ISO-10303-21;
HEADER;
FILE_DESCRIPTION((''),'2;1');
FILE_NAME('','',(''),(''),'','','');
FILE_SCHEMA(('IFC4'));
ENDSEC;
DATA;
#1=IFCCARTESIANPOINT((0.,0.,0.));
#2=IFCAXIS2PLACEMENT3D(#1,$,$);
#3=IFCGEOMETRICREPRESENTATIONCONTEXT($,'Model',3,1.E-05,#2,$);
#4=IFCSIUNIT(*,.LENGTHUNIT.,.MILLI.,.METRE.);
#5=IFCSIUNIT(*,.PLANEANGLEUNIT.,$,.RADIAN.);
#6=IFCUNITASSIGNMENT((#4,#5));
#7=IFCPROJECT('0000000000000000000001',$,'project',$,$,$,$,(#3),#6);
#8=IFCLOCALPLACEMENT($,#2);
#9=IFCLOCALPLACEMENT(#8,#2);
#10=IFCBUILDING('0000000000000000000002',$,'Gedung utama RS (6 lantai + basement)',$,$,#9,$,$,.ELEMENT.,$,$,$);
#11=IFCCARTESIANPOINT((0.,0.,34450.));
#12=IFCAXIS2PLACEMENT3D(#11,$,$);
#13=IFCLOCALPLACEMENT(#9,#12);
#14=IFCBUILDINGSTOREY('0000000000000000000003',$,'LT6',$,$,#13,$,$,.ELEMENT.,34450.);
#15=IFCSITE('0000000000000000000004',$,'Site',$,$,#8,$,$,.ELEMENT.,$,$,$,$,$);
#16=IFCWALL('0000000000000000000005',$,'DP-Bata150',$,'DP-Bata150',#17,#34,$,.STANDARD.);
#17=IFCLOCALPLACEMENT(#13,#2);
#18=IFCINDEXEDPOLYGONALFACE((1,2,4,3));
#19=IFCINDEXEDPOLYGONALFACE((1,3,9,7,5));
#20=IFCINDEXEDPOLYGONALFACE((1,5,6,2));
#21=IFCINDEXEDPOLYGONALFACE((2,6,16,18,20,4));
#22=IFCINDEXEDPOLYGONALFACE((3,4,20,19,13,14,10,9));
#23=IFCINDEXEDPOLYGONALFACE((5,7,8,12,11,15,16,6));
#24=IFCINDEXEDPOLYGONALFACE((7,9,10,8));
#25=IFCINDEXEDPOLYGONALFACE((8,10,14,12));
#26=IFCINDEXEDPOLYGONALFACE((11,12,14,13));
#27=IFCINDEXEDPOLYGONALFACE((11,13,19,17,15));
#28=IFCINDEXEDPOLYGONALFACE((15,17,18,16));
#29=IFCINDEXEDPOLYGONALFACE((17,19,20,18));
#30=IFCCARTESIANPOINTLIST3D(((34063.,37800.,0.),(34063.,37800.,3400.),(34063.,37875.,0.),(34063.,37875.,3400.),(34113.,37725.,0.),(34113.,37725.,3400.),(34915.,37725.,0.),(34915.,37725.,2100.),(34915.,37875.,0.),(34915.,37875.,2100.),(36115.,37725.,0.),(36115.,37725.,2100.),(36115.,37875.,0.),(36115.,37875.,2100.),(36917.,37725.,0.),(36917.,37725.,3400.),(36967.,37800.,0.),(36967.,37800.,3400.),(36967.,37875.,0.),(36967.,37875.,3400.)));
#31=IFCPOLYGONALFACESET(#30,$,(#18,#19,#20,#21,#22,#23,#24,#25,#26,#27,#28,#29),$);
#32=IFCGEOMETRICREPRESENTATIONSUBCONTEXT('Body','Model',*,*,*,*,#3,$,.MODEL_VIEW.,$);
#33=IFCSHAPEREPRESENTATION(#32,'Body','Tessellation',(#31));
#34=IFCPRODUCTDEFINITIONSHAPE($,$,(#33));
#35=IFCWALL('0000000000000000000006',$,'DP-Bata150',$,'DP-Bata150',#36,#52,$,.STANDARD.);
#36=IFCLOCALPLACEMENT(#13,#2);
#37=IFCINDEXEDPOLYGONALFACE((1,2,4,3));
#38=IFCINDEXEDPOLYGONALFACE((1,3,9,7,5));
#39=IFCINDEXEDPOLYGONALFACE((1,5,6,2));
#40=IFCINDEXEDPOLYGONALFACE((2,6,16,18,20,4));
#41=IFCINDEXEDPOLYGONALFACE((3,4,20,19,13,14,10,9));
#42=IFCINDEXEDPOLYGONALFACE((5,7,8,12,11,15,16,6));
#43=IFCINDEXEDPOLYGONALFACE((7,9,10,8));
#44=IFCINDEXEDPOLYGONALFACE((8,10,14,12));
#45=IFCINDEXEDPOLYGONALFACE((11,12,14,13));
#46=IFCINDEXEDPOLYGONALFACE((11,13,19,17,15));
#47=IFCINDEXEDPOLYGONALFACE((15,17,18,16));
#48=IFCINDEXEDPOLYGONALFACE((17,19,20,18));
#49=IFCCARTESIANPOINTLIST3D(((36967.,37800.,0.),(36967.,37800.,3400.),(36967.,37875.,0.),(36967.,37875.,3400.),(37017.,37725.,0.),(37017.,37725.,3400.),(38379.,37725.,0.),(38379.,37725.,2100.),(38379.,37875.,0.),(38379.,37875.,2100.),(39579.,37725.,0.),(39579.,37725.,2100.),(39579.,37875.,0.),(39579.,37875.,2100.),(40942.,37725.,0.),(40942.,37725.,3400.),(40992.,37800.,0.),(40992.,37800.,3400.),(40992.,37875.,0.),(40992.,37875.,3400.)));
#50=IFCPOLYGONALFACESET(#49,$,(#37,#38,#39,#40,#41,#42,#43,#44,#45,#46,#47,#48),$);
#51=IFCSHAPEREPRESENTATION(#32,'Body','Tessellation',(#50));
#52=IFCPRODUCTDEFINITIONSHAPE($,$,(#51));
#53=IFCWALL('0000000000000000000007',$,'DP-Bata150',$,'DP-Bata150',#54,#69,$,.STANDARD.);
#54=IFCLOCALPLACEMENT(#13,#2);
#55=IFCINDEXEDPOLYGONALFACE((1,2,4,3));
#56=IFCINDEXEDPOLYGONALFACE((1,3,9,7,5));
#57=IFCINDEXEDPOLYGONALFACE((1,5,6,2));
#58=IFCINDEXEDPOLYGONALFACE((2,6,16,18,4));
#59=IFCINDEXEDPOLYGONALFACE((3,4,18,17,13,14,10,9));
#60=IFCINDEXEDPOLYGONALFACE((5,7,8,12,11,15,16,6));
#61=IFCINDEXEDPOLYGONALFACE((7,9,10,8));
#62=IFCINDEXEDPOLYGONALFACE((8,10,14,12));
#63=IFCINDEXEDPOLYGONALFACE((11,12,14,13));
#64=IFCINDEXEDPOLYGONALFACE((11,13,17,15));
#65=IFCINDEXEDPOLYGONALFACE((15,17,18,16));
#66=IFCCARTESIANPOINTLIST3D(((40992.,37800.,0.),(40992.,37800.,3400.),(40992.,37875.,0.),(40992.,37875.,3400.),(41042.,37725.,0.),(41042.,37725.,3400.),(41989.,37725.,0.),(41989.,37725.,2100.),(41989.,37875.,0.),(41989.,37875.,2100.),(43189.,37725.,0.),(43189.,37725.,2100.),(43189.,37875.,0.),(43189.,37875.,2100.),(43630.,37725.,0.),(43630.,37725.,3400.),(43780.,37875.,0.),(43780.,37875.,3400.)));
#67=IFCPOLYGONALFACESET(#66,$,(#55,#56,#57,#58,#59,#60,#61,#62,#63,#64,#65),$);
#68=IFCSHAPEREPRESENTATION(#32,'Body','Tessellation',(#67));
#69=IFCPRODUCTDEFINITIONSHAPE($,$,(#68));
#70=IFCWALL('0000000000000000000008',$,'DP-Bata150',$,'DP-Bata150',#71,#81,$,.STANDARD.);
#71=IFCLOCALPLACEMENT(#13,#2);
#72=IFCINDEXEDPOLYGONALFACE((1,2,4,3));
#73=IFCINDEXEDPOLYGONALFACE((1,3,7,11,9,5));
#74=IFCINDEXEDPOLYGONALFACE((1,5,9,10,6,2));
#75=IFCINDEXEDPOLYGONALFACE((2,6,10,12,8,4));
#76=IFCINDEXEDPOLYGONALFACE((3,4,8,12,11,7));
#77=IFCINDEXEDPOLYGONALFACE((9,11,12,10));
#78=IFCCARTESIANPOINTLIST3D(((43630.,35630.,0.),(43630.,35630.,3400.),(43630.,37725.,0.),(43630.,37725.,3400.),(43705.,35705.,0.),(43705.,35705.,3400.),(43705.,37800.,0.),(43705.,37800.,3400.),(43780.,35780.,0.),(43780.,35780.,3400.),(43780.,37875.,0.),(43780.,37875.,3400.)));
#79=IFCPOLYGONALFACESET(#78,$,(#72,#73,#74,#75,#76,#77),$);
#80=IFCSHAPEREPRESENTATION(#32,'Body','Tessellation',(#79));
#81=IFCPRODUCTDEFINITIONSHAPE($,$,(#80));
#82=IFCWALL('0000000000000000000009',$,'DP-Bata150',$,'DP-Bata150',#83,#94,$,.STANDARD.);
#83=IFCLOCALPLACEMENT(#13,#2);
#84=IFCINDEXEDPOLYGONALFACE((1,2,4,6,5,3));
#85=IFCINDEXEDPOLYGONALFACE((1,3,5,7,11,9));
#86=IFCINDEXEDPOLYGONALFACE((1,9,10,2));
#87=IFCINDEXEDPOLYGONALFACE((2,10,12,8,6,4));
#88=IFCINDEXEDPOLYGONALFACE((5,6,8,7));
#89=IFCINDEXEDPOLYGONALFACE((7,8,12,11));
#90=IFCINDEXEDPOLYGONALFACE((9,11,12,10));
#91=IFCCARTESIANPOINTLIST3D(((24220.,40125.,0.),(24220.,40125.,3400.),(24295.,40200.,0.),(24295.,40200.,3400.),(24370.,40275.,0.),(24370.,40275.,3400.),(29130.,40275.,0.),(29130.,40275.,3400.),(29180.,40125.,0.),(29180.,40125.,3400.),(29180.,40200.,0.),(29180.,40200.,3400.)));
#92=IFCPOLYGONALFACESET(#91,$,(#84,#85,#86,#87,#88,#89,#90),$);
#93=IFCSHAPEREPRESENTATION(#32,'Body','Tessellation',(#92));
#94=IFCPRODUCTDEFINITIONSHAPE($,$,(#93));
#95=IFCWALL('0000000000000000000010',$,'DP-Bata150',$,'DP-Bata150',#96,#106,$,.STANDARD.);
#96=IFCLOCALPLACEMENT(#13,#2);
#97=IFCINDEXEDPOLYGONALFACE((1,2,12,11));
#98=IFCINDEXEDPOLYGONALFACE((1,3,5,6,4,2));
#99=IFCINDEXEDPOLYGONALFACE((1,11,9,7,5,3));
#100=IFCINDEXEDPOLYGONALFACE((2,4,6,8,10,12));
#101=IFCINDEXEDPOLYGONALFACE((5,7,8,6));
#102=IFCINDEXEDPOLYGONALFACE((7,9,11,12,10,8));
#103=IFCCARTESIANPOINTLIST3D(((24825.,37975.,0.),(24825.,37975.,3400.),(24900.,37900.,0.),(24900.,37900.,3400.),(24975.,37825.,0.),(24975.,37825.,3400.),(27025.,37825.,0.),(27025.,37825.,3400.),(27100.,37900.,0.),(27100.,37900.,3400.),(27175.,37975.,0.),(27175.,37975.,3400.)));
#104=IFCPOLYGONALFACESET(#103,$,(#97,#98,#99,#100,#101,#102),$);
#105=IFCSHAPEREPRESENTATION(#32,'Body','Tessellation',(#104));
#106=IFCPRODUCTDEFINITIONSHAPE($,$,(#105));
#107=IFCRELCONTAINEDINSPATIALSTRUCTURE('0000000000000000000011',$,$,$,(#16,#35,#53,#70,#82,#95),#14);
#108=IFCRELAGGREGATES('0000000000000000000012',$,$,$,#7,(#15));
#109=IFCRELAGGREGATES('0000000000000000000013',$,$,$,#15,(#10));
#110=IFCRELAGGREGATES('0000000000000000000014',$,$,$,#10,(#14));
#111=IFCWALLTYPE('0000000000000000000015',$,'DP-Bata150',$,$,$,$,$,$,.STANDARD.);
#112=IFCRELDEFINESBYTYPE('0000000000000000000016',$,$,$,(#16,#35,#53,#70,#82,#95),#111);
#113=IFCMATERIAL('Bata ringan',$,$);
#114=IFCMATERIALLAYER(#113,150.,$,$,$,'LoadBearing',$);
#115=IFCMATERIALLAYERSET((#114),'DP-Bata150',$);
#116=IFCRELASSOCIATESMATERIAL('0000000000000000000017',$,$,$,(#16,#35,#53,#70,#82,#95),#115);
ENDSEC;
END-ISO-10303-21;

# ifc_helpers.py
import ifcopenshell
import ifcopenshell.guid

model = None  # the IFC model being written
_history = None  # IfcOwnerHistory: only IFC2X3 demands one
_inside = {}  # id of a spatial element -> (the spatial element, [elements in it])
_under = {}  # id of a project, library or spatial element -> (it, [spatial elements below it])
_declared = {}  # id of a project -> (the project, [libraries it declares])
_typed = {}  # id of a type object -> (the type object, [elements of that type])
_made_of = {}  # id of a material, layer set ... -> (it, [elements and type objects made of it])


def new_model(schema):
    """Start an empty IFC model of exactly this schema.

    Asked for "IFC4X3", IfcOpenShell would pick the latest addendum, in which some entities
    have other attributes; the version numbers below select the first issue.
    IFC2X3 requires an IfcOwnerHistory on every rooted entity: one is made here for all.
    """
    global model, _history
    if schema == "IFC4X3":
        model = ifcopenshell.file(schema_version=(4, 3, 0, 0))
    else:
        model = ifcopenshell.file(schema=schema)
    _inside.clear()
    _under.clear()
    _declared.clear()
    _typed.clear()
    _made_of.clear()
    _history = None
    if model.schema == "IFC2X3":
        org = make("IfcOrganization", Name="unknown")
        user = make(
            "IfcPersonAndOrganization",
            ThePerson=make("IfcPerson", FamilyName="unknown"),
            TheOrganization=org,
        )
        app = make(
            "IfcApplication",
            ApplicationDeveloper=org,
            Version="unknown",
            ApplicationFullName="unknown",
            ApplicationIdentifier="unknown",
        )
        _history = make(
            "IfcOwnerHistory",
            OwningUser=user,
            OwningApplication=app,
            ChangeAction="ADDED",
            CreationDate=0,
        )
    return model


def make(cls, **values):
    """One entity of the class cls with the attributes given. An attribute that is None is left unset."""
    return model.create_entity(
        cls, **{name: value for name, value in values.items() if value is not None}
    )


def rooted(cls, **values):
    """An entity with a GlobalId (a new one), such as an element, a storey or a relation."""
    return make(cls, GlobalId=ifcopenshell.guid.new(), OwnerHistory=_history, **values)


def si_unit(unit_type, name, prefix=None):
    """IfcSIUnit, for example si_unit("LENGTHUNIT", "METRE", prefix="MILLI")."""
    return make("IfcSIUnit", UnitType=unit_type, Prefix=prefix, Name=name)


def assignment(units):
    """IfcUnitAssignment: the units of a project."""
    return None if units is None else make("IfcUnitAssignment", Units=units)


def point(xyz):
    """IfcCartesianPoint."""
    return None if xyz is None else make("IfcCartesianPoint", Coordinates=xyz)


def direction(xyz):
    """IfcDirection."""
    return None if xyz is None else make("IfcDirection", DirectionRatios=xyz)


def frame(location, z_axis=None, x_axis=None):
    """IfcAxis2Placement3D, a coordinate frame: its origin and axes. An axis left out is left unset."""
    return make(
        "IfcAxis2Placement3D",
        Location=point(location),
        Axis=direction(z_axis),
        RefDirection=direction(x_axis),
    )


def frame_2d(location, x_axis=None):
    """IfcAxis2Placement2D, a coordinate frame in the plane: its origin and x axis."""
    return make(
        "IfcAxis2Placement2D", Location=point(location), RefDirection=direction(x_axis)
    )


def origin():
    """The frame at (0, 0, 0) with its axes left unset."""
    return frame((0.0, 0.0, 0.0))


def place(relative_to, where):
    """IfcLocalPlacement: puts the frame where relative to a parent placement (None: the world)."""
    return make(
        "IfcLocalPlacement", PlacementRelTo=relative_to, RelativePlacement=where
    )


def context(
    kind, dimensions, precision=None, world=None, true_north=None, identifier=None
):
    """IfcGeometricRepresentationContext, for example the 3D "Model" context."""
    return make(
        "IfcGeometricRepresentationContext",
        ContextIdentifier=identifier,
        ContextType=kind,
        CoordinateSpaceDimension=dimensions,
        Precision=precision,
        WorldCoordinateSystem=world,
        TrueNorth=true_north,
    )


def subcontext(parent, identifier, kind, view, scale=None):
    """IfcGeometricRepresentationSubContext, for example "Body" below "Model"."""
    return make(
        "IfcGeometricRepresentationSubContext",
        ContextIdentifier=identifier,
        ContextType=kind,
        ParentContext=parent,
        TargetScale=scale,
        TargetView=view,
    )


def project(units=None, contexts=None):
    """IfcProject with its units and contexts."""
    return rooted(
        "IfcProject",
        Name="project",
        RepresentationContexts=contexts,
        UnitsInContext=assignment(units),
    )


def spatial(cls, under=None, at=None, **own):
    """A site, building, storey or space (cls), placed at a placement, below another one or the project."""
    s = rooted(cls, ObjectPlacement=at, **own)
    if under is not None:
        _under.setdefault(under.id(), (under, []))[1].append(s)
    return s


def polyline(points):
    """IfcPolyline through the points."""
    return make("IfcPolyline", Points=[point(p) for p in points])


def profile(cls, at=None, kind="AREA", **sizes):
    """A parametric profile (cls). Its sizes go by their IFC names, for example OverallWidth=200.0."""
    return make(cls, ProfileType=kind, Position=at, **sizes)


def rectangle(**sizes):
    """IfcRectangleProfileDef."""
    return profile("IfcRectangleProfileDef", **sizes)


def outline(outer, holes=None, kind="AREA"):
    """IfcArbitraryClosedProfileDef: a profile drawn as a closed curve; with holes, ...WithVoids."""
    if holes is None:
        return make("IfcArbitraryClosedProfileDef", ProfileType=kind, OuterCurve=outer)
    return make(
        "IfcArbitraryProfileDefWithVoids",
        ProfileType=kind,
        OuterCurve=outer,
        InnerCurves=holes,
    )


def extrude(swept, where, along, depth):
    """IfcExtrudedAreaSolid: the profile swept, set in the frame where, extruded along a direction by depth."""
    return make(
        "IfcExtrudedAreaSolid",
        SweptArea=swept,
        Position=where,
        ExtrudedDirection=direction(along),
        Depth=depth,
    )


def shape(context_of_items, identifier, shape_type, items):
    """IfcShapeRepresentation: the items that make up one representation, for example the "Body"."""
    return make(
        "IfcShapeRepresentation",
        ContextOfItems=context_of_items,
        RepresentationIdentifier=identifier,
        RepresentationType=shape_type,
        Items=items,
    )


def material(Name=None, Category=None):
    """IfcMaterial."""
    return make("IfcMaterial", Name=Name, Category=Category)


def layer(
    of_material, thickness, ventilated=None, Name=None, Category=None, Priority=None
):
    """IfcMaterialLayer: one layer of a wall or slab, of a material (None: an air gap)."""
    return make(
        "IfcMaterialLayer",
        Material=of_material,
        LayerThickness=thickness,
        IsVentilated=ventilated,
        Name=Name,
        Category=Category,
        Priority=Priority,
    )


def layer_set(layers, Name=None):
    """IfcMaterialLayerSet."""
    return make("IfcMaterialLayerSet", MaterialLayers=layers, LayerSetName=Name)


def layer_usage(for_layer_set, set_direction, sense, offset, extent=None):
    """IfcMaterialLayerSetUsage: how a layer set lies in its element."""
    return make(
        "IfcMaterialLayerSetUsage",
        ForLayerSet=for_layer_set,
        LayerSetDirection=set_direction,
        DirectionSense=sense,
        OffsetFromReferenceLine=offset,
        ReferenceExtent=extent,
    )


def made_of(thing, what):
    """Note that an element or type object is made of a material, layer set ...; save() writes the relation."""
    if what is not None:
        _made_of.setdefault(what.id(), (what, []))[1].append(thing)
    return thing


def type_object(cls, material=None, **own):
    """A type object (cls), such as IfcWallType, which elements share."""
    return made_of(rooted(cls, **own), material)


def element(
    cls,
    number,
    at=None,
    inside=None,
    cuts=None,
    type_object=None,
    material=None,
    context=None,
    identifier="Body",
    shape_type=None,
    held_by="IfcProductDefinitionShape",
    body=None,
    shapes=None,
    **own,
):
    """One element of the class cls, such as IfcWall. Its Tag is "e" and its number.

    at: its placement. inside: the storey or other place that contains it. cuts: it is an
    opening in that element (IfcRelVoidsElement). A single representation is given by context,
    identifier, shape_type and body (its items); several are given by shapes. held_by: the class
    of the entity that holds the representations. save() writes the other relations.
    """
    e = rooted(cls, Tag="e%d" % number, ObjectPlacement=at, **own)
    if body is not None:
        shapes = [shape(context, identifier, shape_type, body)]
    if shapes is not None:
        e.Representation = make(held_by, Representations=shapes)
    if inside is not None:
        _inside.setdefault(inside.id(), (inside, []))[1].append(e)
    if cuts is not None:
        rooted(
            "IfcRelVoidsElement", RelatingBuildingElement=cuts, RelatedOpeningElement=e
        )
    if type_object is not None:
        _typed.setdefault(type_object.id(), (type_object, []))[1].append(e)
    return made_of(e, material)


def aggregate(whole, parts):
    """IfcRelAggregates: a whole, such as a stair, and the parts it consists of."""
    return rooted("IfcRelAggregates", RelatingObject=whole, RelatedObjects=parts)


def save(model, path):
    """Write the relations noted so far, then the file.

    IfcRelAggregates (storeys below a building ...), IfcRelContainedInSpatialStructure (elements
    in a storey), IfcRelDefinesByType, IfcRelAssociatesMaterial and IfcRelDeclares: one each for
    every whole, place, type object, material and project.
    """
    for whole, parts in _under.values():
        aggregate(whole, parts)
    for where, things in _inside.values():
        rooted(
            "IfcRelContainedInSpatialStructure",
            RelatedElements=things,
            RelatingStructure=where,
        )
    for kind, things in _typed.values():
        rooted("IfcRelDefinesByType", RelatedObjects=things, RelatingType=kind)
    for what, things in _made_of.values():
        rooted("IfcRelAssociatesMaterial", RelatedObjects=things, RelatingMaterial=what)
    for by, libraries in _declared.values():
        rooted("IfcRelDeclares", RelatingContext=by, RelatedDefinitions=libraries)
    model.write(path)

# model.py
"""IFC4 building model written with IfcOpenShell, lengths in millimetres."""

from ifc_helpers import new_model, si_unit, frame, frame_2d, origin, place, context, subcontext, project, spatial, polyline, rectangle, outline, extrude, material, layer, layer_set, layer_usage, type_object, element, save


model = new_model("IFC4")

# Units and contexts
model_context = context("Model", 3, precision=1e-05, world=origin())
body_context = subcontext(model_context, "Body", "Model", "MODEL_VIEW")
ifc_project = project(units=[si_unit("LENGTHUNIT", "METRE", prefix="MILLI"), si_unit("PLANEANGLEUNIT", "RADIAN")], contexts=[model_context])

# Site, building, storey
site_placement = place(None, origin())
site = spatial("IfcSite", under=ifc_project, at=site_placement, Name="Site", CompositionType="ELEMENT")
building_placement = place(site_placement, origin())
building = spatial("IfcBuilding", under=site, at=building_placement, Name="Gedung utama RS (6 lantai + basement)", CompositionType="ELEMENT")
storey_placement = place(building_placement, frame((0.0, 0.0, 34450.0)))
storey = spatial("IfcBuildingStorey", under=building, at=storey_placement, Name="LT6", CompositionType="ELEMENT", Elevation=34450.0)

# Shared definitions
ifc_material = material(Name="Bata ringan")
ifc_layer_1 = layer(ifc_material, 150.0, Category="LoadBearing")
ifc_layer_set_1 = layer_set([ifc_layer_1], Name="DP-Bata150")
ifc_layer_usage_1 = layer_usage(ifc_layer_set_1, "AXIS2", "NEGATIVE", 75.0)
wall_type_1 = type_object("IfcWallType", Name="DP-Bata150", PredefinedType="STANDARD")

# Walls, openings
wall_1_placement = place(storey_placement, frame((34063.0, 37800.0, 0.0), z_axis=(0.0, 0.0, 1.0), x_axis=(1.0, 0.0, 0.0)))
wall_1 = element("IfcWall", 1, at=wall_1_placement, inside=storey, type_object=wall_type_1, material=ifc_layer_usage_1, Name="DP-Bata150", ObjectType="DP-Bata150", PredefinedType="STANDARD", context=body_context, shape_type="SweptSolid", body=[
    extrude(outline(polyline([(50.0, -75.0), (0.0, 0.0), (0.0, 75.0), (2904.0, 75.0), (2904.0, 0.0), (2854.0, -75.0), (50.0, -75.0)])), origin(), (0.0, 0.0, 1.0), 3400.0),
])
opening_1_placement = place(wall_1_placement, frame((852.0, 0.0, 0.0), z_axis=(0.0, 0.0, 1.0), x_axis=(1.0, 0.0, 0.0)))
element("IfcOpeningElement", 2, at=opening_1_placement, cuts=wall_1, PredefinedType="OPENING", context=body_context, shape_type="SweptSolid", body=[
    extrude(rectangle(XDim=1200.0, YDim=170.0, at=frame_2d((600.0, 0.0))), origin(), (0.0, 0.0, 1.0), 2100.0),
])
wall_2_placement = place(storey_placement, frame((36967.0, 37800.0, 0.0), z_axis=(0.0, 0.0, 1.0), x_axis=(1.0, 0.0, 0.0)))
wall_2 = element("IfcWall", 3, at=wall_2_placement, inside=storey, type_object=wall_type_1, material=ifc_layer_usage_1, Name="DP-Bata150", ObjectType="DP-Bata150", PredefinedType="STANDARD", context=body_context, shape_type="SweptSolid", body=[
    extrude(outline(polyline([(50.0, -75.0), (0.0, 0.0), (0.0, 75.0), (4025.0, 75.0), (4025.0, 0.0), (3975.0, -75.0), (50.0, -75.0)])), origin(), (0.0, 0.0, 1.0), 3400.0),
])
opening_2_placement = place(wall_2_placement, frame((1412.0, 0.0, 0.0), z_axis=(0.0, 0.0, 1.0), x_axis=(1.0, 0.0, 0.0)))
element("IfcOpeningElement", 4, at=opening_2_placement, cuts=wall_2, PredefinedType="OPENING", context=body_context, shape_type="SweptSolid", body=[
    extrude(rectangle(XDim=1200.0, YDim=170.0, at=frame_2d((600.0, 0.0))), origin(), (0.0, 0.0, 1.0), 2100.0),
])
wall_3_placement = place(storey_placement, frame((40992.0, 37800.0, 0.0), z_axis=(0.0, 0.0, 1.0), x_axis=(1.0, 0.0, 0.0)))
wall_3 = element("IfcWall", 5, at=wall_3_placement, inside=storey, type_object=wall_type_1, material=ifc_layer_usage_1, Name="DP-Bata150", ObjectType="DP-Bata150", PredefinedType="STANDARD", context=body_context, shape_type="SweptSolid", body=[
    extrude(outline(polyline([(50.0, -75.0), (0.0, 0.0), (0.0, 75.0), (2788.0, 75.0), (2713.0, 0.0), (2638.0, -75.0), (50.0, -75.0)])), origin(), (0.0, 0.0, 1.0), 3400.0),
])
opening_3_placement = place(wall_3_placement, frame((997.0, 0.0, 0.0), z_axis=(0.0, 0.0, 1.0), x_axis=(1.0, 0.0, 0.0)))
element("IfcOpeningElement", 6, at=opening_3_placement, cuts=wall_3, PredefinedType="OPENING", context=body_context, shape_type="SweptSolid", body=[
    extrude(rectangle(XDim=1200.0, YDim=170.0, at=frame_2d((600.0, 0.0))), origin(), (0.0, 0.0, 1.0), 2100.0),
])

# Walls
wall_4_placement = place(storey_placement, frame((43705.0, 37800.0, 0.0), z_axis=(0.0, 0.0, 1.0), x_axis=(0.0, -1.0, 0.0)))
element("IfcWall", 7, at=wall_4_placement, inside=storey, type_object=wall_type_1, material=ifc_layer_usage_1, Name="DP-Bata150", ObjectType="DP-Bata150", PredefinedType="STANDARD", context=body_context, shape_type="SweptSolid", body=[
    extrude(outline(polyline([(75.0, -75.0), (0.0, 0.0), (-75.0, 75.0), (2020.0, 75.0), (2095.0, 0.0), (2170.0, -75.0), (75.0, -75.0)])), origin(), (0.0, 0.0, 1.0), 3400.0),
])
wall_5_placement = place(storey_placement, frame((29180.0, 40200.0, 0.0), z_axis=(0.0, 0.0, 1.0), x_axis=(-1.0, 0.0, 0.0)))
element("IfcWall", 8, at=wall_5_placement, inside=storey, type_object=wall_type_1, material=ifc_layer_usage_1, Name="DP-Bata150", ObjectType="DP-Bata150", PredefinedType="STANDARD", context=body_context, shape_type="SweptSolid", body=[
    extrude(outline(polyline([(50.0, -75.0), (0.0, 0.0), (0.0, 75.0), (4960.0, 75.0), (4885.0, 0.0), (4810.0, -75.0), (50.0, -75.0)])), origin(), (0.0, 0.0, 1.0), 3400.0),
])
wall_6_placement = place(storey_placement, frame((27100.0, 37900.0, 0.0), z_axis=(0.0, 0.0, 1.0), x_axis=(-1.0, 0.0, 0.0)))
element("IfcWall", 9, at=wall_6_placement, inside=storey, type_object=wall_type_1, material=ifc_layer_usage_1, Name="DP-Bata150", ObjectType="DP-Bata150", PredefinedType="STANDARD", context=body_context, shape_type="SweptSolid", body=[
    extrude(outline(polyline([(-75.0, -75.0), (0.0, 0.0), (75.0, 75.0), (2125.0, 75.0), (2200.0, 0.0), (2275.0, -75.0), (-75.0, -75.0)])), origin(), (0.0, 0.0, 1.0), 3400.0),
])

save(model, "model.ifc")
